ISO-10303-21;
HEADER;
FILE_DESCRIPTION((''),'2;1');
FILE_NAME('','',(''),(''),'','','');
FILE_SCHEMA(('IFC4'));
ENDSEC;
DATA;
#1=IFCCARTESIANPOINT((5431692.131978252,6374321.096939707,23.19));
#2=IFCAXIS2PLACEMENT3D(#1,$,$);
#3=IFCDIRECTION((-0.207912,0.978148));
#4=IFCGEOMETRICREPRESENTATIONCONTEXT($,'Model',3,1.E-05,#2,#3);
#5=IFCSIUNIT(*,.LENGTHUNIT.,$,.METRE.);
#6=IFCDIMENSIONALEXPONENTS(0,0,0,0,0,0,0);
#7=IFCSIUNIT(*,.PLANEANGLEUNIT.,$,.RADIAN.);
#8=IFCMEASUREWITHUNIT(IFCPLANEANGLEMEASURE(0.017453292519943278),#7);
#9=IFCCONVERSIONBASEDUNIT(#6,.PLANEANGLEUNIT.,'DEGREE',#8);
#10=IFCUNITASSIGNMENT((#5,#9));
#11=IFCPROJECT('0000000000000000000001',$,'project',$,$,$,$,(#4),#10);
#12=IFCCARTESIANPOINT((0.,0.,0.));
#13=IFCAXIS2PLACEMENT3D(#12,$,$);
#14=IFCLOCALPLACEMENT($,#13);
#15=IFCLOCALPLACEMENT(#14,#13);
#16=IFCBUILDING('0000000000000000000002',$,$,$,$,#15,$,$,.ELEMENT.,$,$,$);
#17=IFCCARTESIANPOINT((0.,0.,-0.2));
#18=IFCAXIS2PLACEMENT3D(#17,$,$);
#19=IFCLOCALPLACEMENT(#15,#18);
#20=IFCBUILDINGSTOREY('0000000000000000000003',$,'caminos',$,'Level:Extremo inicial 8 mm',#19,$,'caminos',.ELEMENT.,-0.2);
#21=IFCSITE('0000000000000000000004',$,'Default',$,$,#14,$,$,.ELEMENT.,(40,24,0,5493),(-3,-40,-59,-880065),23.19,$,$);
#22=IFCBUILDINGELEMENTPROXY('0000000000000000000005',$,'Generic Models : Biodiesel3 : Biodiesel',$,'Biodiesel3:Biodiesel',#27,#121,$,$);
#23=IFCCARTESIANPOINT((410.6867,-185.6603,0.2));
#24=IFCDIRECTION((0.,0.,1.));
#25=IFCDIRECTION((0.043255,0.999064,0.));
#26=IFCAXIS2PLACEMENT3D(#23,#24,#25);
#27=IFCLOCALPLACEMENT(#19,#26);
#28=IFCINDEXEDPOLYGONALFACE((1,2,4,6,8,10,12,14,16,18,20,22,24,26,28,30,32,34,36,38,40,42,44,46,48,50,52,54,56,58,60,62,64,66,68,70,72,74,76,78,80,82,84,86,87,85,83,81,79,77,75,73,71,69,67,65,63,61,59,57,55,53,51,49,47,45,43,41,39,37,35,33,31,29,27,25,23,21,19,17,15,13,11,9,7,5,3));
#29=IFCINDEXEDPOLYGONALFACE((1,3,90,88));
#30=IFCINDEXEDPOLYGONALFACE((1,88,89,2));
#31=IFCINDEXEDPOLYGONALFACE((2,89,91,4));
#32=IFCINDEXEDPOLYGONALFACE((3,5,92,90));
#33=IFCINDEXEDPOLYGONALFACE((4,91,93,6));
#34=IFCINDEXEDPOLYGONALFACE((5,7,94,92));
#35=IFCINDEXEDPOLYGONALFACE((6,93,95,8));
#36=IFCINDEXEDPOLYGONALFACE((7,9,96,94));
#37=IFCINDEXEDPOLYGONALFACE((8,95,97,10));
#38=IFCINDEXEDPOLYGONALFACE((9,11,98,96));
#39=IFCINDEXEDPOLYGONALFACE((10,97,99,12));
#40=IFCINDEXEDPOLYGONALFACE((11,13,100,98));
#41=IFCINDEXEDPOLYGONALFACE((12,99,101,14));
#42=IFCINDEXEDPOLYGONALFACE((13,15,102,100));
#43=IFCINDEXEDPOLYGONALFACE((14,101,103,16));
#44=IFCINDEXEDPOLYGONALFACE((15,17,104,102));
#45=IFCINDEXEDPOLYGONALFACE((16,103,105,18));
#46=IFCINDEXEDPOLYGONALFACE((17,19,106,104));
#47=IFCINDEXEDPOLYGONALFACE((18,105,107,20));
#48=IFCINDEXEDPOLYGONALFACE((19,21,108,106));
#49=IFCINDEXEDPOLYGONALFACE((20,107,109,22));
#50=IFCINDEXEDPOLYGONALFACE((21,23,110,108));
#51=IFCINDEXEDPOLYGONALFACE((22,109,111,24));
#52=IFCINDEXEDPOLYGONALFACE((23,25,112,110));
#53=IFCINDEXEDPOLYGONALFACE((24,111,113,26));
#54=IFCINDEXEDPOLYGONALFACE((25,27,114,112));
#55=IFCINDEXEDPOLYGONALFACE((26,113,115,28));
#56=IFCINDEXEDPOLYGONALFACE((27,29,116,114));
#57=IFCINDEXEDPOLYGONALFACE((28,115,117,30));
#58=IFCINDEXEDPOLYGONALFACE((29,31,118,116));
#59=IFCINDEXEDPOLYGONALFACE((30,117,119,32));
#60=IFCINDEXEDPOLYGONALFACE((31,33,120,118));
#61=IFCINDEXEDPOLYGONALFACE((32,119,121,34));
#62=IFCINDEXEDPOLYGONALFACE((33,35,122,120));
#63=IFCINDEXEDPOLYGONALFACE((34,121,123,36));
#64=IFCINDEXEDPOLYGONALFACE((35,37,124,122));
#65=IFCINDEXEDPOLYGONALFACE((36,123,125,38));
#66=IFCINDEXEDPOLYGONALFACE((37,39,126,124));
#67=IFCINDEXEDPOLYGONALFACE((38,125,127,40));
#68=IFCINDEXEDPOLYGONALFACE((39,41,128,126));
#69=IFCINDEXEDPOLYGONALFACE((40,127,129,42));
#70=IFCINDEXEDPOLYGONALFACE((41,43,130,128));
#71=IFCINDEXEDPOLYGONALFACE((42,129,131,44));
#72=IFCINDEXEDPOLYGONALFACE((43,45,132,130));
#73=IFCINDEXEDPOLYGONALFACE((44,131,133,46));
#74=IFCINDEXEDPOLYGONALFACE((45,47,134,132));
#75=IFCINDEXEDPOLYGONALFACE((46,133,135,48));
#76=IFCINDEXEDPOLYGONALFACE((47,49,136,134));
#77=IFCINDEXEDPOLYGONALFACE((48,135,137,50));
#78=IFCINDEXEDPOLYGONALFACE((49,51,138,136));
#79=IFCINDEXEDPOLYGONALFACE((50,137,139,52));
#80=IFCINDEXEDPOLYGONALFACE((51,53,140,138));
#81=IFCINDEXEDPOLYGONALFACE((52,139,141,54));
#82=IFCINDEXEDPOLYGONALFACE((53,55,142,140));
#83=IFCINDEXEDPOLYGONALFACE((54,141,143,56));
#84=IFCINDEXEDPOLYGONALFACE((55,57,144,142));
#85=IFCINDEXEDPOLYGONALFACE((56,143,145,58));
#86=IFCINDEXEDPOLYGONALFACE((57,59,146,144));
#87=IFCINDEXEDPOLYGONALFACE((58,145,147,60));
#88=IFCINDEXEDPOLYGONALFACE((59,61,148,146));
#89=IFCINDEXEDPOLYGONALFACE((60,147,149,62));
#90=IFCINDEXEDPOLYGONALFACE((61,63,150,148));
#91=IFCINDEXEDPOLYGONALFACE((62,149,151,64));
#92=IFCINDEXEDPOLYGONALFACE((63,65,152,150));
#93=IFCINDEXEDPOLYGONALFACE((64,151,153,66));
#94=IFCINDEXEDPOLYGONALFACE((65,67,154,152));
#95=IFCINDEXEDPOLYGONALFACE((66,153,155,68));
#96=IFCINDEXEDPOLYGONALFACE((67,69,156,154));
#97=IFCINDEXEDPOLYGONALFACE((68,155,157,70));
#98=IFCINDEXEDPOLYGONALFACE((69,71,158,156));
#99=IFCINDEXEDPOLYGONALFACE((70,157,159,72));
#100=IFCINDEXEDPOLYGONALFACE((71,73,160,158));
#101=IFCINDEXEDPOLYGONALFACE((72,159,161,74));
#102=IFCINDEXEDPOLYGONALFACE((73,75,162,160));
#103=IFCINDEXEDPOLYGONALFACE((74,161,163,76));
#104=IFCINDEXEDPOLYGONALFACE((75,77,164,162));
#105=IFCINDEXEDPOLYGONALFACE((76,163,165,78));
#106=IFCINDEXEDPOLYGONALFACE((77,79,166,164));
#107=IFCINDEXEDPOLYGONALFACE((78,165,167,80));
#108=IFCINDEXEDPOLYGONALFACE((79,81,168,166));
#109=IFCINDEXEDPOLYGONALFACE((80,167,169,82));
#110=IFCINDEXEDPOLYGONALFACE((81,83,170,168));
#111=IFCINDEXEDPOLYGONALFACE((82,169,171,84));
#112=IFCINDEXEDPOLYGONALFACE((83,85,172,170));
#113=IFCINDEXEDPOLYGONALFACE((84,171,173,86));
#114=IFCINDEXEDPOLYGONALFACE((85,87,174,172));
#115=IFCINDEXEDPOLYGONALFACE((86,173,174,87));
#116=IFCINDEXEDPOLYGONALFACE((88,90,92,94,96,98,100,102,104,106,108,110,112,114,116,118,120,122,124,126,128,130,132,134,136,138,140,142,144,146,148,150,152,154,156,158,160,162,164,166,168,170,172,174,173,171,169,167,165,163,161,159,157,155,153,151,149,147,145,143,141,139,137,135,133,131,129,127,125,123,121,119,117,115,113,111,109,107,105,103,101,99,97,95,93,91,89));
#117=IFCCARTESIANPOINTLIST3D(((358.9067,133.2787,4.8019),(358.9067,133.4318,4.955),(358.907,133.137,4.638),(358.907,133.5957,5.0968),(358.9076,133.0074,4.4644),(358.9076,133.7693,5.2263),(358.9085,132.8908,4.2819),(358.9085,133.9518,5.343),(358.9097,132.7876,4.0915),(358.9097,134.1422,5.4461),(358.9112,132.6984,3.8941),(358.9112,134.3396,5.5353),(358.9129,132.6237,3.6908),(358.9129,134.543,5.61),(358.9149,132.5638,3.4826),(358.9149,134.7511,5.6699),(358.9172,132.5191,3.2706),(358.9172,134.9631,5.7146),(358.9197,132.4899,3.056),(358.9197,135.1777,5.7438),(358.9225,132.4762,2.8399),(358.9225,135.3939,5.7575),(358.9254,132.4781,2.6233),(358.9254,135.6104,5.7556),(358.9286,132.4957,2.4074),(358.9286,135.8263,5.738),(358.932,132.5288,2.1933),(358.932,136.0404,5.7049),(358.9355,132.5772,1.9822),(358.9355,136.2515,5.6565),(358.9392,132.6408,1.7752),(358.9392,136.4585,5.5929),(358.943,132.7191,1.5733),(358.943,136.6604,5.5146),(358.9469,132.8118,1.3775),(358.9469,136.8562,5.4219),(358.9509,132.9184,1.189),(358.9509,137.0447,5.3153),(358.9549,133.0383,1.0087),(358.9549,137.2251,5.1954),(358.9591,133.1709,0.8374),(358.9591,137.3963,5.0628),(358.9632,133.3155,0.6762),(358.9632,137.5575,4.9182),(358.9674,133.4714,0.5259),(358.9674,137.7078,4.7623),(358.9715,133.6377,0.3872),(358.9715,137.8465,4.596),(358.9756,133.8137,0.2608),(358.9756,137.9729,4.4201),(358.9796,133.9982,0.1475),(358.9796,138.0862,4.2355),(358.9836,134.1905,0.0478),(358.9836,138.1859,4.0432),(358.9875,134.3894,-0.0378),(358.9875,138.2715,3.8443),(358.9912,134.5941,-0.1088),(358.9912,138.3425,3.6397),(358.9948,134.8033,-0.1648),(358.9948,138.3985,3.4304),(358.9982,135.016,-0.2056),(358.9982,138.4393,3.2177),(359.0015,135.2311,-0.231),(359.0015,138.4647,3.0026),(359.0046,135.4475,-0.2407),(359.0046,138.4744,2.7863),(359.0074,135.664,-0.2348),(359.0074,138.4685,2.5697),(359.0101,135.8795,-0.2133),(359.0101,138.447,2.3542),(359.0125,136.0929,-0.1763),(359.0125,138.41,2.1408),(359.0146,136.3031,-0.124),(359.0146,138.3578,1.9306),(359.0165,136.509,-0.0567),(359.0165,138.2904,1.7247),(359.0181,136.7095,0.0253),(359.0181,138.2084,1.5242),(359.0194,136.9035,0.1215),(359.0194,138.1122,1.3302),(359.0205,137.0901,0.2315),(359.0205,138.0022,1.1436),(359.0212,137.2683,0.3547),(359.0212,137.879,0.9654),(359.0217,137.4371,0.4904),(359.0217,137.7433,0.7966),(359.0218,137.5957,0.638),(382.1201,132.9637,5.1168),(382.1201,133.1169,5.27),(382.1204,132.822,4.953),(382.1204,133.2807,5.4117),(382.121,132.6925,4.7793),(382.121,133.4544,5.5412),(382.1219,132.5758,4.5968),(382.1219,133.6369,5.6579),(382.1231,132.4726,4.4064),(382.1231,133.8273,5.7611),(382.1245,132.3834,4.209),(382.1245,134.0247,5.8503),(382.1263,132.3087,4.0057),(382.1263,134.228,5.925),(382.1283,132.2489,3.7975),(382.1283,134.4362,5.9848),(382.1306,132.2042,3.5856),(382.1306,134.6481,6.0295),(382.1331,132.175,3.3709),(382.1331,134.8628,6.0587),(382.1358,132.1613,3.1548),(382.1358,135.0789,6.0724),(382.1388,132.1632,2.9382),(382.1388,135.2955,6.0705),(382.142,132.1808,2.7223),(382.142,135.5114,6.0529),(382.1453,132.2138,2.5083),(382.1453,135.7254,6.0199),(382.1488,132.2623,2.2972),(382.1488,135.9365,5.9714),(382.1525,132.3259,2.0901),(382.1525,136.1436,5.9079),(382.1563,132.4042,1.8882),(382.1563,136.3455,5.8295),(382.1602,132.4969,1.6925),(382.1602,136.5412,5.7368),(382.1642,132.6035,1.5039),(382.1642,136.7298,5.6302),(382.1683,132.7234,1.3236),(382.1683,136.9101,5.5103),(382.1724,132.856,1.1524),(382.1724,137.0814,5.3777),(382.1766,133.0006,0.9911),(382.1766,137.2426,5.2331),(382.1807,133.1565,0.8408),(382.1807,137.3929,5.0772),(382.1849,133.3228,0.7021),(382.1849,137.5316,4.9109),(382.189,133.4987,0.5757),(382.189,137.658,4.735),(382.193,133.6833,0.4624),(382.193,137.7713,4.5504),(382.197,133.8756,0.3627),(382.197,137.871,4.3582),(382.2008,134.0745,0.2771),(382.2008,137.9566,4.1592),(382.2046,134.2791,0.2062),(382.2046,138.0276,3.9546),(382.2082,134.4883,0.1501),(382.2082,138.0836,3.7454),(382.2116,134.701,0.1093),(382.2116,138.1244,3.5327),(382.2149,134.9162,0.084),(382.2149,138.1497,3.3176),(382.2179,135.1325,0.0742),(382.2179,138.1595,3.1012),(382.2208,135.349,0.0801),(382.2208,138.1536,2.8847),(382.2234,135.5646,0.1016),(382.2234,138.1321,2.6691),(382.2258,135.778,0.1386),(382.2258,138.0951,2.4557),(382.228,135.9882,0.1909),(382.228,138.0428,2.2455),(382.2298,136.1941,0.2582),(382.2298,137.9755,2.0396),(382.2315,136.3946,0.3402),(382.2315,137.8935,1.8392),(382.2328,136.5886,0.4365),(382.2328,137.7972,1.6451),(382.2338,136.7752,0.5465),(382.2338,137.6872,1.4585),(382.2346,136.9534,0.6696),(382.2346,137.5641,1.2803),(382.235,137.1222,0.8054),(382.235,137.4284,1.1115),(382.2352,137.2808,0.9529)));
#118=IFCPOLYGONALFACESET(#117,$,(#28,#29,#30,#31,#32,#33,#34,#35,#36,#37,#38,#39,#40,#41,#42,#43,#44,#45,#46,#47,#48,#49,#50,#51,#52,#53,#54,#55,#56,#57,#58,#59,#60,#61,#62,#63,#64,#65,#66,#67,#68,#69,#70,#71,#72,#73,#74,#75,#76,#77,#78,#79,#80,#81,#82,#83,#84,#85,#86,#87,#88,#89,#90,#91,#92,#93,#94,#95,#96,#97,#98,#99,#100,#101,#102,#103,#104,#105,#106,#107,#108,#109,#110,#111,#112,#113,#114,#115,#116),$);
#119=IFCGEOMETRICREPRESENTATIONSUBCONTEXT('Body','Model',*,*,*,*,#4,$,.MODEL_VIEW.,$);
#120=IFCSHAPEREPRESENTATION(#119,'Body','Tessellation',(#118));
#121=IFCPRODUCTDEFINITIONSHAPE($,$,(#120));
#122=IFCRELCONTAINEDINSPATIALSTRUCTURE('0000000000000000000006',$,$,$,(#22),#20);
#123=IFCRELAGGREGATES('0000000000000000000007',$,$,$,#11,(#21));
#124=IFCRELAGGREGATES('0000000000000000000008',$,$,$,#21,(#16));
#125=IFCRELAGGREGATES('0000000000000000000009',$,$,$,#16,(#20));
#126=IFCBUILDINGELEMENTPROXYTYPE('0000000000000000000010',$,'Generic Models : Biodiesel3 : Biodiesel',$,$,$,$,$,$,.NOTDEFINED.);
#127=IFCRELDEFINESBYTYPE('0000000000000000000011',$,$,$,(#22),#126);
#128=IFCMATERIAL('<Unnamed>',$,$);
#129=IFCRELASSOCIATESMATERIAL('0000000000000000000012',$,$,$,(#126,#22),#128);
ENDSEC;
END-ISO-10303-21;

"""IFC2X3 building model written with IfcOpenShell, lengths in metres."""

from ifc_helpers import new_model, entity, si_unit, converted_unit, direction, frame, frame_2d, origin, place, context, subcontext, project, spatial, circle, extrude, source, transform, mapped, material, type_object, type_shapes, element, save


model = new_model("IFC2X3")

# Units and contexts
model_context = context("Model", 3, precision=1e-05, world=frame((5431692.131978252, 6374321.096939707, 23.19)), true_north=direction((-0.207912, 0.978148)))
body_context = subcontext(model_context, "Body", "Model", "MODEL_VIEW")
ifc_project = project(units=[si_unit("LENGTHUNIT", "METRE"), converted_unit("PLANEANGLEUNIT", "DEGREE", entity("IfcPlaneAngleMeasure", 0.017453292519943278), si_unit("PLANEANGLEUNIT", "RADIAN"), dimensions=[0, 0, 0, 0, 0, 0, 0])], contexts=[model_context])

# Site, building, storey
site_placement = place(None, origin())
site = spatial("IfcSite", under=ifc_project, at=site_placement, Name="Default", CompositionType="ELEMENT", RefLatitude=(40, 24, 0, 5493), RefLongitude=(-3, -40, -59, -880065), RefElevation=23.19)
building_placement = place(site_placement, origin())
building = spatial("IfcBuilding", under=site, at=building_placement, CompositionType="ELEMENT")
storey_placement = place(building_placement, frame((0.0, 0.0, -0.2)))
storey = spatial("IfcBuildingStorey", under=building, at=storey_placement, Name="caminos", ObjectType="Level:Extremo inicial 8 mm", LongName="caminos", CompositionType="ELEMENT", Elevation=-0.2)

# Building element proxy
ifc_material_1 = material(Name="<Unnamed>")
building_element_proxy_type_1 = type_object("IfcBuildingElementProxyType", Name="Generic Models : Biodiesel3 : Biodiesel", PredefinedType="NOTDEFINED", material=ifc_material_1)
shared_shape_1 = source(origin(), body_context, "Body", "SweptSolid", [
    extrude(circle(Radius=3.0, at=frame_2d((0.0, 0.0), x_axis=(1.0, 0.0))), frame((358.9643, 135.4748, 2.7589), z_axis=(0.999816, -0.013564, 0.013564), x_axis=(0.019183, 0.706977, -0.706977)), (0.0, 0.0, 1.0), 23.2176),
])
type_shapes(building_element_proxy_type_1, [shared_shape_1])
proxy_1_placement = place(storey_placement, frame((410.6867, -185.6603, 0.2), z_axis=(0.0, 0.0, 1.0), x_axis=(0.043255, 0.999064, 0.0)))
element("IfcBuildingElementProxy", 1, at=proxy_1_placement, inside=storey, type_object=building_element_proxy_type_1, material=ifc_material_1, Name="Generic Models : Biodiesel3 : Biodiesel", ObjectType="Biodiesel3:Biodiesel", context=body_context, shape_type="MappedRepresentation", body=[
    mapped(shared_shape_1, transform((0.0, 0.0, 0.0), scale=1.0)),
])

save(model, "model.ifc")
